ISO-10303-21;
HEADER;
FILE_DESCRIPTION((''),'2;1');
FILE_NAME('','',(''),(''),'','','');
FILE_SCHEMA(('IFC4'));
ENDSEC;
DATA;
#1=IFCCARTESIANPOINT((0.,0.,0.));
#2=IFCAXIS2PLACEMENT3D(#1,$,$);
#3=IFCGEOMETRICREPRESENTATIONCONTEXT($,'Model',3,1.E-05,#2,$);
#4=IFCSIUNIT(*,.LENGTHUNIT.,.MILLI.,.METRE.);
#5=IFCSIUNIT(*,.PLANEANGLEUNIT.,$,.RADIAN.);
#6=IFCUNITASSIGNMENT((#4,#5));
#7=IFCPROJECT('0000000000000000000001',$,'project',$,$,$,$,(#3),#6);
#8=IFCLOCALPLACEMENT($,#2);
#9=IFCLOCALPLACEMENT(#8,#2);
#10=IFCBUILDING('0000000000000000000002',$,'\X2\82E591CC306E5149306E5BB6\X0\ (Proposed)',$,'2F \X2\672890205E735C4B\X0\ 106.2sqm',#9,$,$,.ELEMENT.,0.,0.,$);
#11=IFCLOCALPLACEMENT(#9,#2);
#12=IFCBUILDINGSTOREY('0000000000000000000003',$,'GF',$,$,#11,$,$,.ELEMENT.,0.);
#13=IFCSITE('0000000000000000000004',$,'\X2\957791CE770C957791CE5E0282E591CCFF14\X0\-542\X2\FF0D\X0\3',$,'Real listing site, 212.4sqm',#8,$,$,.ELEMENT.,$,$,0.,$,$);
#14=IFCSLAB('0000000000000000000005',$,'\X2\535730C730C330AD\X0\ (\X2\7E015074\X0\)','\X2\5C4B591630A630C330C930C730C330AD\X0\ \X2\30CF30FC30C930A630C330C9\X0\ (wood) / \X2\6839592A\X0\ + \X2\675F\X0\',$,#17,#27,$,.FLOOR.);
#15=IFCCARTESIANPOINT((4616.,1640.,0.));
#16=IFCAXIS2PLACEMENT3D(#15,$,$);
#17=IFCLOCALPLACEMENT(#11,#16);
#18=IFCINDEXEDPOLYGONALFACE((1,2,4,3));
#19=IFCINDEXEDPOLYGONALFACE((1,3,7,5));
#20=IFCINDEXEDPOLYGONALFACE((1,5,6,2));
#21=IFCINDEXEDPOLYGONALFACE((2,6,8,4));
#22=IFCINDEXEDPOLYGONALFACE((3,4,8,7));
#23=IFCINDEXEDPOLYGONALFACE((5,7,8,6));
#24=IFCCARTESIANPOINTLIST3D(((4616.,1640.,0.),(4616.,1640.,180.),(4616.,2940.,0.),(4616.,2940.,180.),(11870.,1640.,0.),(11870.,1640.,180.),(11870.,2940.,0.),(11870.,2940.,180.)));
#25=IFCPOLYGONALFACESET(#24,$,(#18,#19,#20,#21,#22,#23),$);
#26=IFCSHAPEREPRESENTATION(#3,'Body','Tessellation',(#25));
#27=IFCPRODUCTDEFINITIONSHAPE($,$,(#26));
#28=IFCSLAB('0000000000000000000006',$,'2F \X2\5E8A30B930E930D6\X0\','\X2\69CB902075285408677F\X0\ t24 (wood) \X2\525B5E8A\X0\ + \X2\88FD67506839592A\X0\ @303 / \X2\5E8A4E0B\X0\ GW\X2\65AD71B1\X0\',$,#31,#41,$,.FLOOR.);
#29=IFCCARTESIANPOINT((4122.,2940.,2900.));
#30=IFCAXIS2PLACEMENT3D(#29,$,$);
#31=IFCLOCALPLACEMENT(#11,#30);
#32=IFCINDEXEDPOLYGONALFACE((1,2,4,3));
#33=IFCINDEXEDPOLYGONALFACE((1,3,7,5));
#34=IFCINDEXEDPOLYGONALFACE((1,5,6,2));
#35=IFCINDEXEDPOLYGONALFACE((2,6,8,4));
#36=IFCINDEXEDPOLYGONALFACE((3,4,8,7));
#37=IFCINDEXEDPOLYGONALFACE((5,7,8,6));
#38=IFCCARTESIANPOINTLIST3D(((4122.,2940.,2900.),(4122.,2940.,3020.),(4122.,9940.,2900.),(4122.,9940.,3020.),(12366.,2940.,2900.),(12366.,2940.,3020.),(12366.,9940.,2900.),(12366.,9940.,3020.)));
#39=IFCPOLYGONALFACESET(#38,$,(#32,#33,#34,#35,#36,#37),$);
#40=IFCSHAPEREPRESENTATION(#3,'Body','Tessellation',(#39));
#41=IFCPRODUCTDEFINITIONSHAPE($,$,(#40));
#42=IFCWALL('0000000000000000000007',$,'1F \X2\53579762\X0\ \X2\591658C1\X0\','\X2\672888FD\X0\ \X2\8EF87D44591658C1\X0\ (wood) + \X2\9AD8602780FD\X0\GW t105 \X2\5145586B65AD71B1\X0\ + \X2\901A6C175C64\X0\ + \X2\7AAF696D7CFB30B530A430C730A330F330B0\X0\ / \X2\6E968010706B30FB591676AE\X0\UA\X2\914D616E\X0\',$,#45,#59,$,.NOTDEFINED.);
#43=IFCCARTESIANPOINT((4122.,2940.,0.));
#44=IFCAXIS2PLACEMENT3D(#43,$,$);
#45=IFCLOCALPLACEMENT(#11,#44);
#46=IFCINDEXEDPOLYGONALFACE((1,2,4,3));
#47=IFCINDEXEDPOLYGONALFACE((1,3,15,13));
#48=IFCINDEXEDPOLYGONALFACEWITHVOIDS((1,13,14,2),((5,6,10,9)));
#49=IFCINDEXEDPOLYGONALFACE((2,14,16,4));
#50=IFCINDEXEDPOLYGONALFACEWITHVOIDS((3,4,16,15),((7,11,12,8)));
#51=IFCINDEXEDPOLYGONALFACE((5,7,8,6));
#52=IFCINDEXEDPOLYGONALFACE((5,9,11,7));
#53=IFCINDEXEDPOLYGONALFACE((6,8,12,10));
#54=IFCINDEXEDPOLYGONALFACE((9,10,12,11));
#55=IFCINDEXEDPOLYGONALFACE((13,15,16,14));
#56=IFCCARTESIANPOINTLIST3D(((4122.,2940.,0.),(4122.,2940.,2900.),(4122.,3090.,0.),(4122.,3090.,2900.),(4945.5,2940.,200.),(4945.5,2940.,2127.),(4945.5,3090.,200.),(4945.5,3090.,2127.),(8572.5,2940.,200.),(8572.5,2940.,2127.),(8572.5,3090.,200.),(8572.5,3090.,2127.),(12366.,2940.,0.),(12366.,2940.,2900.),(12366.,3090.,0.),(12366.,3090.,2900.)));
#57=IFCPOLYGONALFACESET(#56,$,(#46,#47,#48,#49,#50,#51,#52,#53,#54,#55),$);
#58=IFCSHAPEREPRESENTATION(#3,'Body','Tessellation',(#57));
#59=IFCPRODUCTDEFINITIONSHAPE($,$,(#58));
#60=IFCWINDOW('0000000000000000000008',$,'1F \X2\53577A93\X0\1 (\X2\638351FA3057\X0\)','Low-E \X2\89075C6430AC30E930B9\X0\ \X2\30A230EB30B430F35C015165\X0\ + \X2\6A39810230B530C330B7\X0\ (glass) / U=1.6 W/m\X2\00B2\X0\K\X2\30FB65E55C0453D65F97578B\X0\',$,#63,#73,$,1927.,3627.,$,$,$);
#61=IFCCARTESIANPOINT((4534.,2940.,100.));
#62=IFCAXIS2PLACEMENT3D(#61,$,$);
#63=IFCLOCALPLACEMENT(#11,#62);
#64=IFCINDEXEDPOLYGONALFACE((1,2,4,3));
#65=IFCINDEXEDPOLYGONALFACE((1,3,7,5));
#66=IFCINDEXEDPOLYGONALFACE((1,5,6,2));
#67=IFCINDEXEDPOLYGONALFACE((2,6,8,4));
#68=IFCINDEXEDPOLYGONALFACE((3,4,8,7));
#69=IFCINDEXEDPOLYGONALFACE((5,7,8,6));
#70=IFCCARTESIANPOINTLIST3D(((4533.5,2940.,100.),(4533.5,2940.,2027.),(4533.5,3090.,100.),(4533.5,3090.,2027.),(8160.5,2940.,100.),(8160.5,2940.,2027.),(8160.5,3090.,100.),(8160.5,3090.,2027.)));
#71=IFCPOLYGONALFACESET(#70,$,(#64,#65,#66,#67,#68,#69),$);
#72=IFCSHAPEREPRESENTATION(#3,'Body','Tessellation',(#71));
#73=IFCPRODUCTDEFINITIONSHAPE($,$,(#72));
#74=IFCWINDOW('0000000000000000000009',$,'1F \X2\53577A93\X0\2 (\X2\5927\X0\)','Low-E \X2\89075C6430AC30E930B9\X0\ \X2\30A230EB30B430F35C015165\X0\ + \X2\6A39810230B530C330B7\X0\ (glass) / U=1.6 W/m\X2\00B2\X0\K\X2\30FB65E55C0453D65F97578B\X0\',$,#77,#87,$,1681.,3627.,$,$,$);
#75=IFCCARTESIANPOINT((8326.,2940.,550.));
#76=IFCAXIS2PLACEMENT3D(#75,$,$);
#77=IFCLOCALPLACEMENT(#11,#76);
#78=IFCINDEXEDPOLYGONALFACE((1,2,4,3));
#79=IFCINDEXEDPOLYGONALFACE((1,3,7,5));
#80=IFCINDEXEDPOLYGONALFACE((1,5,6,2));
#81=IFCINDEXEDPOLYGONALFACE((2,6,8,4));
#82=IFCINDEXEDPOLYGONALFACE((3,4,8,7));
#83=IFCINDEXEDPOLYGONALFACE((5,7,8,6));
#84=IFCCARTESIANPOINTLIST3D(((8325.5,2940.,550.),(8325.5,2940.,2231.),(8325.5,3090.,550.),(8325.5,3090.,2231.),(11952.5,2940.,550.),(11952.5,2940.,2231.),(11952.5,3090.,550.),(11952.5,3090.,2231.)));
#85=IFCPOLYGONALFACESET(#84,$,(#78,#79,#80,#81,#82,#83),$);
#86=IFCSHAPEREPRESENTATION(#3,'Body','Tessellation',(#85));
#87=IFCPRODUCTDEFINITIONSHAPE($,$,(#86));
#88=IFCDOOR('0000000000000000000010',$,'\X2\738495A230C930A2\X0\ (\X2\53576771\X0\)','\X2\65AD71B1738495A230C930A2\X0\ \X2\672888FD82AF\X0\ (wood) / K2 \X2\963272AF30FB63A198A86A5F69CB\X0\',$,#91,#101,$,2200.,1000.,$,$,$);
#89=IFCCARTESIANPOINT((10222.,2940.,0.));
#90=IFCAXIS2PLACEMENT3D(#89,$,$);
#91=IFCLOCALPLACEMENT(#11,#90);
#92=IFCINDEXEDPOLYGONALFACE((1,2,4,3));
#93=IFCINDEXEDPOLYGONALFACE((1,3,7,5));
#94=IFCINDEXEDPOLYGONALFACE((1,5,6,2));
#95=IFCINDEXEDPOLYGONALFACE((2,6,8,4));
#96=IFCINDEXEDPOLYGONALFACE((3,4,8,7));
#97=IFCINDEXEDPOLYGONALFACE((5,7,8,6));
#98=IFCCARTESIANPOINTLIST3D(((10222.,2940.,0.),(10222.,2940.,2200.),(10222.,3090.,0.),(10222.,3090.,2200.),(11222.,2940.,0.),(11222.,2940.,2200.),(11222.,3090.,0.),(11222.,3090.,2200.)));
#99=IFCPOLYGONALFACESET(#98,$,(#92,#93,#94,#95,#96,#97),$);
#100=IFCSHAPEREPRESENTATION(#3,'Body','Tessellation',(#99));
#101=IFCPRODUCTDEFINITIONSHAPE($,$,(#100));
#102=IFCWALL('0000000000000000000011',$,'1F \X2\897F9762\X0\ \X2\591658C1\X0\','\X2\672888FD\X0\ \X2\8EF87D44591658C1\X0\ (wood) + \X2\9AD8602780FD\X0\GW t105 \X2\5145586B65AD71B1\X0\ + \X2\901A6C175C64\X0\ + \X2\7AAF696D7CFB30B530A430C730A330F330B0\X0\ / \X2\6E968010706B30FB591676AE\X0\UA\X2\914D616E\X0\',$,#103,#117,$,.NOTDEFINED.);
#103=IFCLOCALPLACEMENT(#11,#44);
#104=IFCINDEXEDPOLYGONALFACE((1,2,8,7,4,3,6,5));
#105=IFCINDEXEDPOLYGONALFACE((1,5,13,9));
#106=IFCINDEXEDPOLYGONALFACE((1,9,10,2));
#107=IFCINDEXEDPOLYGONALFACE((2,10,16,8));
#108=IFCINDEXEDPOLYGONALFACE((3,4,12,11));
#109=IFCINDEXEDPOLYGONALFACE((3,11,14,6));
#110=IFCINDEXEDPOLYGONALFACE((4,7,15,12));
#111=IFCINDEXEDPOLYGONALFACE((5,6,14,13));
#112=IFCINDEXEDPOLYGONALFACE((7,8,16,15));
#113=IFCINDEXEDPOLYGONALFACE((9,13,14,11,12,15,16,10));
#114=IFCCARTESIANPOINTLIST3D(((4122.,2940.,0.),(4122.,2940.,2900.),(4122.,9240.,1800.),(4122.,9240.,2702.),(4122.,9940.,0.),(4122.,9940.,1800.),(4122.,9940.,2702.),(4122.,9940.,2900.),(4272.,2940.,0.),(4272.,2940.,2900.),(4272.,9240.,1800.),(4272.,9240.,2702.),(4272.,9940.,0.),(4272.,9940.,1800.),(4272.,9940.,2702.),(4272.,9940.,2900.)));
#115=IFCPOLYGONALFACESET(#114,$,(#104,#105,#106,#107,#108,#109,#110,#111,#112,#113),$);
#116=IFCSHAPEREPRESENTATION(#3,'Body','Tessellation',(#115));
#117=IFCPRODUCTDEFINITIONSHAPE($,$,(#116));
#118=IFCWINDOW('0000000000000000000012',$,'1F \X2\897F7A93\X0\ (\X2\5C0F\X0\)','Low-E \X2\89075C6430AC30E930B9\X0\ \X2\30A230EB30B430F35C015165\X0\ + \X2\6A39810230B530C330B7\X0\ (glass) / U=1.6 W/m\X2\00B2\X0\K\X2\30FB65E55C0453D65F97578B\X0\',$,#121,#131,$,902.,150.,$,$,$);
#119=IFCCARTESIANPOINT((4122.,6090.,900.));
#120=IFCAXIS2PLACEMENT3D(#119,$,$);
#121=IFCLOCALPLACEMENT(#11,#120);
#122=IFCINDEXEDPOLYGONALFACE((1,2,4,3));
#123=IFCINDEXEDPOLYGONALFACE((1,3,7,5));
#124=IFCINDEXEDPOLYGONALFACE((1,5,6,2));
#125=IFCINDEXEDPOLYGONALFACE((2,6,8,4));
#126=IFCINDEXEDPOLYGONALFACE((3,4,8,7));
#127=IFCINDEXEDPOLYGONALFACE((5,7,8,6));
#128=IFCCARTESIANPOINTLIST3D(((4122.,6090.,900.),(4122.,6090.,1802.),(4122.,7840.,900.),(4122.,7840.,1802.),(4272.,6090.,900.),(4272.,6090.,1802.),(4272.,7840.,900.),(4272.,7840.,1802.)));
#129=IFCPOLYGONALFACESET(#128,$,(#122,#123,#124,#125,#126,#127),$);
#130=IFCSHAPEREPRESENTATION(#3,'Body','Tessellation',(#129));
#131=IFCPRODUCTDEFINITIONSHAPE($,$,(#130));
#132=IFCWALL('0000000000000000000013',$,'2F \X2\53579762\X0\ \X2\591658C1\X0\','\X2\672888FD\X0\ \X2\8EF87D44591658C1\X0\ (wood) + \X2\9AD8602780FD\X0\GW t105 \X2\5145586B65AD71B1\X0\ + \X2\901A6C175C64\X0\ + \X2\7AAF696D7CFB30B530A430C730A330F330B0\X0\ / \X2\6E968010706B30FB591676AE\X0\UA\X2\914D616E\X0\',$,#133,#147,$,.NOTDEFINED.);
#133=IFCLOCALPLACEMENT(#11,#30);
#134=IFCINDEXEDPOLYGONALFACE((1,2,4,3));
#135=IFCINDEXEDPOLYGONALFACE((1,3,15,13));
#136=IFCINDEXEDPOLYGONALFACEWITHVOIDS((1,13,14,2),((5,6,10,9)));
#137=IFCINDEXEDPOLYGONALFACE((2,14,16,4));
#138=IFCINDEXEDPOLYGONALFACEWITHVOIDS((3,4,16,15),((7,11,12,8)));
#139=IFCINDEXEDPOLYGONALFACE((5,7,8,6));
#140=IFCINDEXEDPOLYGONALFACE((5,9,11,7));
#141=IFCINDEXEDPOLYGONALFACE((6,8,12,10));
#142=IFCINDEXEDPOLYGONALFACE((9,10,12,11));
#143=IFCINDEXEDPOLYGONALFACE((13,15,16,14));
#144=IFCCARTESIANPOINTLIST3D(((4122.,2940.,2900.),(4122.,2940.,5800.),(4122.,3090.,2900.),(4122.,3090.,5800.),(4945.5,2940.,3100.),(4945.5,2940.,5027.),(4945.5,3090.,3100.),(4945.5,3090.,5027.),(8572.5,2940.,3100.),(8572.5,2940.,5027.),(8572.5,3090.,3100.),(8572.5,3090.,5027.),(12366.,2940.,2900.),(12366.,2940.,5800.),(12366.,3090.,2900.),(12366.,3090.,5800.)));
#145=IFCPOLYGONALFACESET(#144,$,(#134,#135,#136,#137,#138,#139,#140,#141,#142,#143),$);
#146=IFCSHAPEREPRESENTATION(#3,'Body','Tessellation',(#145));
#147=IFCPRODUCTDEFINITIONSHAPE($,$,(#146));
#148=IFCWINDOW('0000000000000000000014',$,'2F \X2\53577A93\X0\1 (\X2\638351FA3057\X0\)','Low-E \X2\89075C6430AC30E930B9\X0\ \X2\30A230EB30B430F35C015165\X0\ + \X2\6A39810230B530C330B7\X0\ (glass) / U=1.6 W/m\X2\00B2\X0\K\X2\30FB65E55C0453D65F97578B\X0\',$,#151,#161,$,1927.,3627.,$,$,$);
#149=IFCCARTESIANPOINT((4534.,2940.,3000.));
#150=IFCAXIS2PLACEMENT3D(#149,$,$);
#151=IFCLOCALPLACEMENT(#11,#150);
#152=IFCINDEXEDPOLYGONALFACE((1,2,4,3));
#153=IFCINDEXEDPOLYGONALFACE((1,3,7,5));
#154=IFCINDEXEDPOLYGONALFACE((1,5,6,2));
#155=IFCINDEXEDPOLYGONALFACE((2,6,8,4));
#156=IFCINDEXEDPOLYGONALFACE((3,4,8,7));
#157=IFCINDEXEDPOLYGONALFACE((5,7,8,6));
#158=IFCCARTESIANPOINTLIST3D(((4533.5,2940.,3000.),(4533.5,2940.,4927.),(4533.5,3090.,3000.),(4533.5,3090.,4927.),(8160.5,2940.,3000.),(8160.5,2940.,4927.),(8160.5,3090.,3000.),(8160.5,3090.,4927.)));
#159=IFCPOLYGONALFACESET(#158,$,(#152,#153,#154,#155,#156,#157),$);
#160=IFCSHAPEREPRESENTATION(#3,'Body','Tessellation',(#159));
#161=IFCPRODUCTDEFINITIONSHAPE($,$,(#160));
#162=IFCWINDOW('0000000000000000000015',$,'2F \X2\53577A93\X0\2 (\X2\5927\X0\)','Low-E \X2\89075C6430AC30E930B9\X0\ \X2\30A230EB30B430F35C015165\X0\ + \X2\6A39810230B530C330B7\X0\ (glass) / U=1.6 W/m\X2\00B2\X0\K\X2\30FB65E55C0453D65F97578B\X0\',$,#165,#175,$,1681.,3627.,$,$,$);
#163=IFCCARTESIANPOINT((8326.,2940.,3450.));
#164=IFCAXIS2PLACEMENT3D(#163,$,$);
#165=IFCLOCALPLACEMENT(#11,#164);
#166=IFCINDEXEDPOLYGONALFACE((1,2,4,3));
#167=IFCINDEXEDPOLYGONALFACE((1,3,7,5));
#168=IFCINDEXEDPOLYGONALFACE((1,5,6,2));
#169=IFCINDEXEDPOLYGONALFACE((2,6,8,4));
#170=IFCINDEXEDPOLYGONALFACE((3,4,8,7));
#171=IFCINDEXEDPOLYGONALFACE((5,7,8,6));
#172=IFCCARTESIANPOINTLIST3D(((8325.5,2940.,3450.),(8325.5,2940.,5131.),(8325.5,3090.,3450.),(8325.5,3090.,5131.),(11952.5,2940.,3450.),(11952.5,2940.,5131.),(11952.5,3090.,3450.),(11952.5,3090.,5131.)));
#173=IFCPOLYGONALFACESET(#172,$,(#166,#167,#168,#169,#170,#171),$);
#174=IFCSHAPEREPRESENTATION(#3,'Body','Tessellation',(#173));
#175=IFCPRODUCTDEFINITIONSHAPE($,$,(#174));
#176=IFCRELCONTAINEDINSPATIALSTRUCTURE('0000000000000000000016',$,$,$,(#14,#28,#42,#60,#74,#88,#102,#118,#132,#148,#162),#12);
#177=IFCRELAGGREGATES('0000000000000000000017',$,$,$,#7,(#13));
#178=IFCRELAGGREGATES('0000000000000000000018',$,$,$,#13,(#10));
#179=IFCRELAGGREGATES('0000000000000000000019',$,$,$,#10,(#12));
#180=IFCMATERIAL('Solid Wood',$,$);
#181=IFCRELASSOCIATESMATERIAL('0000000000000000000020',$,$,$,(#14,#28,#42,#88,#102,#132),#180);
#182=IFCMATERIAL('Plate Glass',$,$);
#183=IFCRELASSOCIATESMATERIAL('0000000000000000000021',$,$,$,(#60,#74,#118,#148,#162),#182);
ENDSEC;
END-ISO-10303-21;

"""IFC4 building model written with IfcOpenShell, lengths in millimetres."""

from ifc_helpers import new_model, si_unit, frame, frame_2d, origin, place, context, project, spatial, rectangle, extrude, material, element, fill, save


model = new_model("IFC4")

# Units and contexts
model_context = context("Model", 3, precision=1e-05, world=origin())
ifc_project = project(units=[si_unit("LENGTHUNIT", "METRE", prefix="MILLI"), si_unit("PLANEANGLEUNIT", "RADIAN")], contexts=[model_context])

# Site, building, storey
site_placement = place(None, origin())
site = spatial("IfcSite", under=ifc_project, at=site_placement, Name="長野県長野市若里４-542－3", ObjectType="Real listing site, 212.4sqm", CompositionType="ELEMENT", RefElevation=0.0)
building_placement = place(site_placement, origin())
building = spatial("IfcBuilding", under=site, at=building_placement, Name="若里の光の家 (Proposed)", ObjectType="2F 木造平屋 106.2sqm", CompositionType="ELEMENT", ElevationOfRefHeight=0.0, ElevationOfTerrain=0.0)
storey_placement = place(building_placement, origin())
storey = spatial("IfcBuildingStorey", under=building, at=storey_placement, Name="GF", CompositionType="ELEMENT", Elevation=0.0)

# Slabs
ifc_material_1 = material(Name="Solid Wood")
slab_1_placement = place(storey_placement, frame((4616.0, 1640.0, 0.0)))
element("IfcSlab", 1, at=slab_1_placement, inside=storey, material=ifc_material_1, Name="南デッキ (縁側)", Description="屋外ウッドデッキ ハードウッド (wood) / 根太 + 束", PredefinedType="FLOOR", context=model_context, shape_type="SweptSolid", body=[
    extrude(rectangle(XDim=7254.0, YDim=1300.0, at=frame_2d((3627.0, 650.0))), frame((4616.0, 1640.0, 0.0)), (0.0, 0.0, 1.0), 180.0),
])
slab_2_placement = place(storey_placement, frame((4122.0, 2940.0, 2900.0)))
element("IfcSlab", 2, at=slab_2_placement, inside=storey, material=ifc_material_1, Name="2F 床スラブ", Description="構造用合板 t24 (wood) 剛床 + 製材根太 @303 / 床下 GW断熱", PredefinedType="FLOOR", context=model_context, shape_type="SweptSolid", body=[
    extrude(rectangle(XDim=8244.0, YDim=7000.0, at=frame_2d((4122.0, 3500.0))), frame((4122.0, 2940.0, 2900.0)), (0.0, 0.0, 1.0), 120.0),
])

# Wall, openings, windows, door
wall_1_placement = place(storey_placement, frame((4122.0, 2940.0, 0.0)))
wall_1 = element("IfcWall", 3, at=wall_1_placement, inside=storey, material=ifc_material_1, Name="1F 南面 外壁", Description="木製 軸組外壁 (wood) + 高性能GW t105 充填断熱 + 通気層 + 窯業系サイディング / 準耐火・外皮UA配慮", PredefinedType="NOTDEFINED", context=model_context, shape_type="SweptSolid", body=[
    extrude(rectangle(XDim=8244.0, YDim=150.0, at=frame_2d((4122.0, 75.0))), frame((4122.0, 2940.0, 0.0)), (0.0, 0.0, 1.0), 2900.0),
])
opening_1_placement = place(storey_placement, frame((4534.0, 2940.0, 100.0)))
opening_1 = element("IfcOpeningElement", 4, at=opening_1_placement, cuts=wall_1, PredefinedType="NOTDEFINED", context=model_context, shape_type="SweptSolid", body=[
    extrude(rectangle(XDim=3627.0, YDim=150.0, at=frame_2d((1813.0, 75.0))), frame((4534.0, 2940.0, 100.0)), (0.0, 0.0, 1.0), 1927.0),
])
opening_2_placement = place(storey_placement, frame((8326.0, 2940.0, 550.0)))
opening_2 = element("IfcOpeningElement", 5, at=opening_2_placement, cuts=wall_1, PredefinedType="NOTDEFINED", context=model_context, shape_type="SweptSolid", body=[
    extrude(rectangle(XDim=3627.0, YDim=150.0, at=frame_2d((1813.0, 75.0))), frame((8326.0, 2940.0, 550.0)), (0.0, 0.0, 1.0), 1681.0),
])
opening_3_placement = place(storey_placement, frame((10222.0, 2940.0, 0.0)))
opening_3 = element("IfcOpeningElement", 6, at=opening_3_placement, cuts=wall_1, PredefinedType="NOTDEFINED", context=model_context, shape_type="SweptSolid", body=[
    extrude(rectangle(XDim=1000.0, YDim=150.0, at=frame_2d((500.0, 75.0))), frame((10222.0, 2940.0, 0.0)), (0.0, 0.0, 1.0), 2200.0),
])
ifc_material_2 = material(Name="Plate Glass")
window_1_placement = place(storey_placement, frame((4534.0, 2940.0, 100.0)))
window_1 = element("IfcWindow", 7, at=window_1_placement, inside=storey, material=ifc_material_2, Name="1F 南窓1 (掃出し)", Description="Low-E 複層ガラス アルゴン封入 + 樹脂サッシ (glass) / U=1.6 W/m²K・日射取得型", OverallHeight=1927.0, OverallWidth=3627.0, context=model_context, shape_type="SweptSolid", body=[
    extrude(rectangle(XDim=3627.0, YDim=150.0, at=frame_2d((1813.0, 75.0))), frame((4534.0, 2940.0, 100.0)), (0.0, 0.0, 1.0), 1927.0),
])
fill(opening_1, window_1)
window_2_placement = place(storey_placement, frame((8326.0, 2940.0, 550.0)))
window_2 = element("IfcWindow", 8, at=window_2_placement, inside=storey, material=ifc_material_2, Name="1F 南窓2 (大)", Description="Low-E 複層ガラス アルゴン封入 + 樹脂サッシ (glass) / U=1.6 W/m²K・日射取得型", OverallHeight=1681.0, OverallWidth=3627.0, context=model_context, shape_type="SweptSolid", body=[
    extrude(rectangle(XDim=3627.0, YDim=150.0, at=frame_2d((1813.0, 75.0))), frame((8326.0, 2940.0, 550.0)), (0.0, 0.0, 1.0), 1681.0),
])
fill(opening_2, window_2)
door_placement = place(storey_placement, frame((10222.0, 2940.0, 0.0)))
door = element("IfcDoor", 9, at=door_placement, inside=storey, material=ifc_material_1, Name="玄関ドア (南東)", Description="断熱玄関ドア 木製芯 (wood) / K2 防犯・採風機構", OverallHeight=2200.0, OverallWidth=1000.0, context=model_context, shape_type="SweptSolid", body=[
    extrude(rectangle(XDim=1000.0, YDim=150.0, at=frame_2d((500.0, 75.0))), frame((10222.0, 2940.0, 0.0)), (0.0, 0.0, 1.0), 2200.0),
])
fill(opening_3, door)

# Wall, opening, window
wall_2_placement = place(storey_placement, frame((4122.0, 2940.0, 0.0)))
wall_2 = element("IfcWall", 10, at=wall_2_placement, inside=storey, material=ifc_material_1, Name="1F 西面 外壁", Description="木製 軸組外壁 (wood) + 高性能GW t105 充填断熱 + 通気層 + 窯業系サイディング / 準耐火・外皮UA配慮", PredefinedType="NOTDEFINED", context=model_context, shape_type="SweptSolid", body=[
    extrude(rectangle(XDim=150.0, YDim=7000.0, at=frame_2d((75.0, 3500.0))), frame((4122.0, 2940.0, 0.0)), (0.0, 0.0, 1.0), 2900.0),
])
opening_4_placement = place(storey_placement, frame((4122.0, 6090.0, 900.0)))
opening_4 = element("IfcOpeningElement", 11, at=opening_4_placement, cuts=wall_2, PredefinedType="NOTDEFINED", context=model_context, shape_type="SweptSolid", body=[
    extrude(rectangle(XDim=150.0, YDim=1750.0, at=frame_2d((75.0, 875.0))), frame((4122.0, 6090.0, 900.0)), (0.0, 0.0, 1.0), 902.0),
])
window_3_placement = place(storey_placement, frame((4122.0, 6090.0, 900.0)))
window_3 = element("IfcWindow", 12, at=window_3_placement, inside=storey, material=ifc_material_2, Name="1F 西窓 (小)", Description="Low-E 複層ガラス アルゴン封入 + 樹脂サッシ (glass) / U=1.6 W/m²K・日射取得型", OverallHeight=902.0, OverallWidth=150.0, context=model_context, shape_type="SweptSolid", body=[
    extrude(rectangle(XDim=150.0, YDim=1750.0, at=frame_2d((75.0, 875.0))), frame((4122.0, 6090.0, 900.0)), (0.0, 0.0, 1.0), 902.0),
])
fill(opening_4, window_3)

# Wall, openings, windows
wall_3_placement = place(storey_placement, frame((4122.0, 2940.0, 2900.0)))
wall_3 = element("IfcWall", 13, at=wall_3_placement, inside=storey, material=ifc_material_1, Name="2F 南面 外壁", Description="木製 軸組外壁 (wood) + 高性能GW t105 充填断熱 + 通気層 + 窯業系サイディング / 準耐火・外皮UA配慮", PredefinedType="NOTDEFINED", context=model_context, shape_type="SweptSolid", body=[
    extrude(rectangle(XDim=8244.0, YDim=150.0, at=frame_2d((4122.0, 75.0))), frame((4122.0, 2940.0, 2900.0)), (0.0, 0.0, 1.0), 2900.0),
])
opening_5_placement = place(storey_placement, frame((4534.0, 2940.0, 3000.0)))
opening_5 = element("IfcOpeningElement", 14, at=opening_5_placement, cuts=wall_3, PredefinedType="NOTDEFINED", context=model_context, shape_type="SweptSolid", body=[
    extrude(rectangle(XDim=3627.0, YDim=150.0, at=frame_2d((1813.0, 75.0))), frame((4534.0, 2940.0, 3000.0)), (0.0, 0.0, 1.0), 1927.0),
])
opening_6_placement = place(storey_placement, frame((8326.0, 2940.0, 3450.0)))
opening_6 = element("IfcOpeningElement", 15, at=opening_6_placement, cuts=wall_3, PredefinedType="NOTDEFINED", context=model_context, shape_type="SweptSolid", body=[
    extrude(rectangle(XDim=3627.0, YDim=150.0, at=frame_2d((1813.0, 75.0))), frame((8326.0, 2940.0, 3450.0)), (0.0, 0.0, 1.0), 1681.0),
])
window_4_placement = place(storey_placement, frame((4534.0, 2940.0, 3000.0)))
window_4 = element("IfcWindow", 16, at=window_4_placement, inside=storey, material=ifc_material_2, Name="2F 南窓1 (掃出し)", Description="Low-E 複層ガラス アルゴン封入 + 樹脂サッシ (glass) / U=1.6 W/m²K・日射取得型", OverallHeight=1927.0, OverallWidth=3627.0, context=model_context, shape_type="SweptSolid", body=[
    extrude(rectangle(XDim=3627.0, YDim=150.0, at=frame_2d((1813.0, 75.0))), frame((4534.0, 2940.0, 3000.0)), (0.0, 0.0, 1.0), 1927.0),
])
fill(opening_5, window_4)
window_5_placement = place(storey_placement, frame((8326.0, 2940.0, 3450.0)))
window_5 = element("IfcWindow", 17, at=window_5_placement, inside=storey, material=ifc_material_2, Name="2F 南窓2 (大)", Description="Low-E 複層ガラス アルゴン封入 + 樹脂サッシ (glass) / U=1.6 W/m²K・日射取得型", OverallHeight=1681.0, OverallWidth=3627.0, context=model_context, shape_type="SweptSolid", body=[
    extrude(rectangle(XDim=3627.0, YDim=150.0, at=frame_2d((1813.0, 75.0))), frame((8326.0, 2940.0, 3450.0)), (0.0, 0.0, 1.0), 1681.0),
])
fill(opening_6, window_5)

save(model, "model.ifc")
